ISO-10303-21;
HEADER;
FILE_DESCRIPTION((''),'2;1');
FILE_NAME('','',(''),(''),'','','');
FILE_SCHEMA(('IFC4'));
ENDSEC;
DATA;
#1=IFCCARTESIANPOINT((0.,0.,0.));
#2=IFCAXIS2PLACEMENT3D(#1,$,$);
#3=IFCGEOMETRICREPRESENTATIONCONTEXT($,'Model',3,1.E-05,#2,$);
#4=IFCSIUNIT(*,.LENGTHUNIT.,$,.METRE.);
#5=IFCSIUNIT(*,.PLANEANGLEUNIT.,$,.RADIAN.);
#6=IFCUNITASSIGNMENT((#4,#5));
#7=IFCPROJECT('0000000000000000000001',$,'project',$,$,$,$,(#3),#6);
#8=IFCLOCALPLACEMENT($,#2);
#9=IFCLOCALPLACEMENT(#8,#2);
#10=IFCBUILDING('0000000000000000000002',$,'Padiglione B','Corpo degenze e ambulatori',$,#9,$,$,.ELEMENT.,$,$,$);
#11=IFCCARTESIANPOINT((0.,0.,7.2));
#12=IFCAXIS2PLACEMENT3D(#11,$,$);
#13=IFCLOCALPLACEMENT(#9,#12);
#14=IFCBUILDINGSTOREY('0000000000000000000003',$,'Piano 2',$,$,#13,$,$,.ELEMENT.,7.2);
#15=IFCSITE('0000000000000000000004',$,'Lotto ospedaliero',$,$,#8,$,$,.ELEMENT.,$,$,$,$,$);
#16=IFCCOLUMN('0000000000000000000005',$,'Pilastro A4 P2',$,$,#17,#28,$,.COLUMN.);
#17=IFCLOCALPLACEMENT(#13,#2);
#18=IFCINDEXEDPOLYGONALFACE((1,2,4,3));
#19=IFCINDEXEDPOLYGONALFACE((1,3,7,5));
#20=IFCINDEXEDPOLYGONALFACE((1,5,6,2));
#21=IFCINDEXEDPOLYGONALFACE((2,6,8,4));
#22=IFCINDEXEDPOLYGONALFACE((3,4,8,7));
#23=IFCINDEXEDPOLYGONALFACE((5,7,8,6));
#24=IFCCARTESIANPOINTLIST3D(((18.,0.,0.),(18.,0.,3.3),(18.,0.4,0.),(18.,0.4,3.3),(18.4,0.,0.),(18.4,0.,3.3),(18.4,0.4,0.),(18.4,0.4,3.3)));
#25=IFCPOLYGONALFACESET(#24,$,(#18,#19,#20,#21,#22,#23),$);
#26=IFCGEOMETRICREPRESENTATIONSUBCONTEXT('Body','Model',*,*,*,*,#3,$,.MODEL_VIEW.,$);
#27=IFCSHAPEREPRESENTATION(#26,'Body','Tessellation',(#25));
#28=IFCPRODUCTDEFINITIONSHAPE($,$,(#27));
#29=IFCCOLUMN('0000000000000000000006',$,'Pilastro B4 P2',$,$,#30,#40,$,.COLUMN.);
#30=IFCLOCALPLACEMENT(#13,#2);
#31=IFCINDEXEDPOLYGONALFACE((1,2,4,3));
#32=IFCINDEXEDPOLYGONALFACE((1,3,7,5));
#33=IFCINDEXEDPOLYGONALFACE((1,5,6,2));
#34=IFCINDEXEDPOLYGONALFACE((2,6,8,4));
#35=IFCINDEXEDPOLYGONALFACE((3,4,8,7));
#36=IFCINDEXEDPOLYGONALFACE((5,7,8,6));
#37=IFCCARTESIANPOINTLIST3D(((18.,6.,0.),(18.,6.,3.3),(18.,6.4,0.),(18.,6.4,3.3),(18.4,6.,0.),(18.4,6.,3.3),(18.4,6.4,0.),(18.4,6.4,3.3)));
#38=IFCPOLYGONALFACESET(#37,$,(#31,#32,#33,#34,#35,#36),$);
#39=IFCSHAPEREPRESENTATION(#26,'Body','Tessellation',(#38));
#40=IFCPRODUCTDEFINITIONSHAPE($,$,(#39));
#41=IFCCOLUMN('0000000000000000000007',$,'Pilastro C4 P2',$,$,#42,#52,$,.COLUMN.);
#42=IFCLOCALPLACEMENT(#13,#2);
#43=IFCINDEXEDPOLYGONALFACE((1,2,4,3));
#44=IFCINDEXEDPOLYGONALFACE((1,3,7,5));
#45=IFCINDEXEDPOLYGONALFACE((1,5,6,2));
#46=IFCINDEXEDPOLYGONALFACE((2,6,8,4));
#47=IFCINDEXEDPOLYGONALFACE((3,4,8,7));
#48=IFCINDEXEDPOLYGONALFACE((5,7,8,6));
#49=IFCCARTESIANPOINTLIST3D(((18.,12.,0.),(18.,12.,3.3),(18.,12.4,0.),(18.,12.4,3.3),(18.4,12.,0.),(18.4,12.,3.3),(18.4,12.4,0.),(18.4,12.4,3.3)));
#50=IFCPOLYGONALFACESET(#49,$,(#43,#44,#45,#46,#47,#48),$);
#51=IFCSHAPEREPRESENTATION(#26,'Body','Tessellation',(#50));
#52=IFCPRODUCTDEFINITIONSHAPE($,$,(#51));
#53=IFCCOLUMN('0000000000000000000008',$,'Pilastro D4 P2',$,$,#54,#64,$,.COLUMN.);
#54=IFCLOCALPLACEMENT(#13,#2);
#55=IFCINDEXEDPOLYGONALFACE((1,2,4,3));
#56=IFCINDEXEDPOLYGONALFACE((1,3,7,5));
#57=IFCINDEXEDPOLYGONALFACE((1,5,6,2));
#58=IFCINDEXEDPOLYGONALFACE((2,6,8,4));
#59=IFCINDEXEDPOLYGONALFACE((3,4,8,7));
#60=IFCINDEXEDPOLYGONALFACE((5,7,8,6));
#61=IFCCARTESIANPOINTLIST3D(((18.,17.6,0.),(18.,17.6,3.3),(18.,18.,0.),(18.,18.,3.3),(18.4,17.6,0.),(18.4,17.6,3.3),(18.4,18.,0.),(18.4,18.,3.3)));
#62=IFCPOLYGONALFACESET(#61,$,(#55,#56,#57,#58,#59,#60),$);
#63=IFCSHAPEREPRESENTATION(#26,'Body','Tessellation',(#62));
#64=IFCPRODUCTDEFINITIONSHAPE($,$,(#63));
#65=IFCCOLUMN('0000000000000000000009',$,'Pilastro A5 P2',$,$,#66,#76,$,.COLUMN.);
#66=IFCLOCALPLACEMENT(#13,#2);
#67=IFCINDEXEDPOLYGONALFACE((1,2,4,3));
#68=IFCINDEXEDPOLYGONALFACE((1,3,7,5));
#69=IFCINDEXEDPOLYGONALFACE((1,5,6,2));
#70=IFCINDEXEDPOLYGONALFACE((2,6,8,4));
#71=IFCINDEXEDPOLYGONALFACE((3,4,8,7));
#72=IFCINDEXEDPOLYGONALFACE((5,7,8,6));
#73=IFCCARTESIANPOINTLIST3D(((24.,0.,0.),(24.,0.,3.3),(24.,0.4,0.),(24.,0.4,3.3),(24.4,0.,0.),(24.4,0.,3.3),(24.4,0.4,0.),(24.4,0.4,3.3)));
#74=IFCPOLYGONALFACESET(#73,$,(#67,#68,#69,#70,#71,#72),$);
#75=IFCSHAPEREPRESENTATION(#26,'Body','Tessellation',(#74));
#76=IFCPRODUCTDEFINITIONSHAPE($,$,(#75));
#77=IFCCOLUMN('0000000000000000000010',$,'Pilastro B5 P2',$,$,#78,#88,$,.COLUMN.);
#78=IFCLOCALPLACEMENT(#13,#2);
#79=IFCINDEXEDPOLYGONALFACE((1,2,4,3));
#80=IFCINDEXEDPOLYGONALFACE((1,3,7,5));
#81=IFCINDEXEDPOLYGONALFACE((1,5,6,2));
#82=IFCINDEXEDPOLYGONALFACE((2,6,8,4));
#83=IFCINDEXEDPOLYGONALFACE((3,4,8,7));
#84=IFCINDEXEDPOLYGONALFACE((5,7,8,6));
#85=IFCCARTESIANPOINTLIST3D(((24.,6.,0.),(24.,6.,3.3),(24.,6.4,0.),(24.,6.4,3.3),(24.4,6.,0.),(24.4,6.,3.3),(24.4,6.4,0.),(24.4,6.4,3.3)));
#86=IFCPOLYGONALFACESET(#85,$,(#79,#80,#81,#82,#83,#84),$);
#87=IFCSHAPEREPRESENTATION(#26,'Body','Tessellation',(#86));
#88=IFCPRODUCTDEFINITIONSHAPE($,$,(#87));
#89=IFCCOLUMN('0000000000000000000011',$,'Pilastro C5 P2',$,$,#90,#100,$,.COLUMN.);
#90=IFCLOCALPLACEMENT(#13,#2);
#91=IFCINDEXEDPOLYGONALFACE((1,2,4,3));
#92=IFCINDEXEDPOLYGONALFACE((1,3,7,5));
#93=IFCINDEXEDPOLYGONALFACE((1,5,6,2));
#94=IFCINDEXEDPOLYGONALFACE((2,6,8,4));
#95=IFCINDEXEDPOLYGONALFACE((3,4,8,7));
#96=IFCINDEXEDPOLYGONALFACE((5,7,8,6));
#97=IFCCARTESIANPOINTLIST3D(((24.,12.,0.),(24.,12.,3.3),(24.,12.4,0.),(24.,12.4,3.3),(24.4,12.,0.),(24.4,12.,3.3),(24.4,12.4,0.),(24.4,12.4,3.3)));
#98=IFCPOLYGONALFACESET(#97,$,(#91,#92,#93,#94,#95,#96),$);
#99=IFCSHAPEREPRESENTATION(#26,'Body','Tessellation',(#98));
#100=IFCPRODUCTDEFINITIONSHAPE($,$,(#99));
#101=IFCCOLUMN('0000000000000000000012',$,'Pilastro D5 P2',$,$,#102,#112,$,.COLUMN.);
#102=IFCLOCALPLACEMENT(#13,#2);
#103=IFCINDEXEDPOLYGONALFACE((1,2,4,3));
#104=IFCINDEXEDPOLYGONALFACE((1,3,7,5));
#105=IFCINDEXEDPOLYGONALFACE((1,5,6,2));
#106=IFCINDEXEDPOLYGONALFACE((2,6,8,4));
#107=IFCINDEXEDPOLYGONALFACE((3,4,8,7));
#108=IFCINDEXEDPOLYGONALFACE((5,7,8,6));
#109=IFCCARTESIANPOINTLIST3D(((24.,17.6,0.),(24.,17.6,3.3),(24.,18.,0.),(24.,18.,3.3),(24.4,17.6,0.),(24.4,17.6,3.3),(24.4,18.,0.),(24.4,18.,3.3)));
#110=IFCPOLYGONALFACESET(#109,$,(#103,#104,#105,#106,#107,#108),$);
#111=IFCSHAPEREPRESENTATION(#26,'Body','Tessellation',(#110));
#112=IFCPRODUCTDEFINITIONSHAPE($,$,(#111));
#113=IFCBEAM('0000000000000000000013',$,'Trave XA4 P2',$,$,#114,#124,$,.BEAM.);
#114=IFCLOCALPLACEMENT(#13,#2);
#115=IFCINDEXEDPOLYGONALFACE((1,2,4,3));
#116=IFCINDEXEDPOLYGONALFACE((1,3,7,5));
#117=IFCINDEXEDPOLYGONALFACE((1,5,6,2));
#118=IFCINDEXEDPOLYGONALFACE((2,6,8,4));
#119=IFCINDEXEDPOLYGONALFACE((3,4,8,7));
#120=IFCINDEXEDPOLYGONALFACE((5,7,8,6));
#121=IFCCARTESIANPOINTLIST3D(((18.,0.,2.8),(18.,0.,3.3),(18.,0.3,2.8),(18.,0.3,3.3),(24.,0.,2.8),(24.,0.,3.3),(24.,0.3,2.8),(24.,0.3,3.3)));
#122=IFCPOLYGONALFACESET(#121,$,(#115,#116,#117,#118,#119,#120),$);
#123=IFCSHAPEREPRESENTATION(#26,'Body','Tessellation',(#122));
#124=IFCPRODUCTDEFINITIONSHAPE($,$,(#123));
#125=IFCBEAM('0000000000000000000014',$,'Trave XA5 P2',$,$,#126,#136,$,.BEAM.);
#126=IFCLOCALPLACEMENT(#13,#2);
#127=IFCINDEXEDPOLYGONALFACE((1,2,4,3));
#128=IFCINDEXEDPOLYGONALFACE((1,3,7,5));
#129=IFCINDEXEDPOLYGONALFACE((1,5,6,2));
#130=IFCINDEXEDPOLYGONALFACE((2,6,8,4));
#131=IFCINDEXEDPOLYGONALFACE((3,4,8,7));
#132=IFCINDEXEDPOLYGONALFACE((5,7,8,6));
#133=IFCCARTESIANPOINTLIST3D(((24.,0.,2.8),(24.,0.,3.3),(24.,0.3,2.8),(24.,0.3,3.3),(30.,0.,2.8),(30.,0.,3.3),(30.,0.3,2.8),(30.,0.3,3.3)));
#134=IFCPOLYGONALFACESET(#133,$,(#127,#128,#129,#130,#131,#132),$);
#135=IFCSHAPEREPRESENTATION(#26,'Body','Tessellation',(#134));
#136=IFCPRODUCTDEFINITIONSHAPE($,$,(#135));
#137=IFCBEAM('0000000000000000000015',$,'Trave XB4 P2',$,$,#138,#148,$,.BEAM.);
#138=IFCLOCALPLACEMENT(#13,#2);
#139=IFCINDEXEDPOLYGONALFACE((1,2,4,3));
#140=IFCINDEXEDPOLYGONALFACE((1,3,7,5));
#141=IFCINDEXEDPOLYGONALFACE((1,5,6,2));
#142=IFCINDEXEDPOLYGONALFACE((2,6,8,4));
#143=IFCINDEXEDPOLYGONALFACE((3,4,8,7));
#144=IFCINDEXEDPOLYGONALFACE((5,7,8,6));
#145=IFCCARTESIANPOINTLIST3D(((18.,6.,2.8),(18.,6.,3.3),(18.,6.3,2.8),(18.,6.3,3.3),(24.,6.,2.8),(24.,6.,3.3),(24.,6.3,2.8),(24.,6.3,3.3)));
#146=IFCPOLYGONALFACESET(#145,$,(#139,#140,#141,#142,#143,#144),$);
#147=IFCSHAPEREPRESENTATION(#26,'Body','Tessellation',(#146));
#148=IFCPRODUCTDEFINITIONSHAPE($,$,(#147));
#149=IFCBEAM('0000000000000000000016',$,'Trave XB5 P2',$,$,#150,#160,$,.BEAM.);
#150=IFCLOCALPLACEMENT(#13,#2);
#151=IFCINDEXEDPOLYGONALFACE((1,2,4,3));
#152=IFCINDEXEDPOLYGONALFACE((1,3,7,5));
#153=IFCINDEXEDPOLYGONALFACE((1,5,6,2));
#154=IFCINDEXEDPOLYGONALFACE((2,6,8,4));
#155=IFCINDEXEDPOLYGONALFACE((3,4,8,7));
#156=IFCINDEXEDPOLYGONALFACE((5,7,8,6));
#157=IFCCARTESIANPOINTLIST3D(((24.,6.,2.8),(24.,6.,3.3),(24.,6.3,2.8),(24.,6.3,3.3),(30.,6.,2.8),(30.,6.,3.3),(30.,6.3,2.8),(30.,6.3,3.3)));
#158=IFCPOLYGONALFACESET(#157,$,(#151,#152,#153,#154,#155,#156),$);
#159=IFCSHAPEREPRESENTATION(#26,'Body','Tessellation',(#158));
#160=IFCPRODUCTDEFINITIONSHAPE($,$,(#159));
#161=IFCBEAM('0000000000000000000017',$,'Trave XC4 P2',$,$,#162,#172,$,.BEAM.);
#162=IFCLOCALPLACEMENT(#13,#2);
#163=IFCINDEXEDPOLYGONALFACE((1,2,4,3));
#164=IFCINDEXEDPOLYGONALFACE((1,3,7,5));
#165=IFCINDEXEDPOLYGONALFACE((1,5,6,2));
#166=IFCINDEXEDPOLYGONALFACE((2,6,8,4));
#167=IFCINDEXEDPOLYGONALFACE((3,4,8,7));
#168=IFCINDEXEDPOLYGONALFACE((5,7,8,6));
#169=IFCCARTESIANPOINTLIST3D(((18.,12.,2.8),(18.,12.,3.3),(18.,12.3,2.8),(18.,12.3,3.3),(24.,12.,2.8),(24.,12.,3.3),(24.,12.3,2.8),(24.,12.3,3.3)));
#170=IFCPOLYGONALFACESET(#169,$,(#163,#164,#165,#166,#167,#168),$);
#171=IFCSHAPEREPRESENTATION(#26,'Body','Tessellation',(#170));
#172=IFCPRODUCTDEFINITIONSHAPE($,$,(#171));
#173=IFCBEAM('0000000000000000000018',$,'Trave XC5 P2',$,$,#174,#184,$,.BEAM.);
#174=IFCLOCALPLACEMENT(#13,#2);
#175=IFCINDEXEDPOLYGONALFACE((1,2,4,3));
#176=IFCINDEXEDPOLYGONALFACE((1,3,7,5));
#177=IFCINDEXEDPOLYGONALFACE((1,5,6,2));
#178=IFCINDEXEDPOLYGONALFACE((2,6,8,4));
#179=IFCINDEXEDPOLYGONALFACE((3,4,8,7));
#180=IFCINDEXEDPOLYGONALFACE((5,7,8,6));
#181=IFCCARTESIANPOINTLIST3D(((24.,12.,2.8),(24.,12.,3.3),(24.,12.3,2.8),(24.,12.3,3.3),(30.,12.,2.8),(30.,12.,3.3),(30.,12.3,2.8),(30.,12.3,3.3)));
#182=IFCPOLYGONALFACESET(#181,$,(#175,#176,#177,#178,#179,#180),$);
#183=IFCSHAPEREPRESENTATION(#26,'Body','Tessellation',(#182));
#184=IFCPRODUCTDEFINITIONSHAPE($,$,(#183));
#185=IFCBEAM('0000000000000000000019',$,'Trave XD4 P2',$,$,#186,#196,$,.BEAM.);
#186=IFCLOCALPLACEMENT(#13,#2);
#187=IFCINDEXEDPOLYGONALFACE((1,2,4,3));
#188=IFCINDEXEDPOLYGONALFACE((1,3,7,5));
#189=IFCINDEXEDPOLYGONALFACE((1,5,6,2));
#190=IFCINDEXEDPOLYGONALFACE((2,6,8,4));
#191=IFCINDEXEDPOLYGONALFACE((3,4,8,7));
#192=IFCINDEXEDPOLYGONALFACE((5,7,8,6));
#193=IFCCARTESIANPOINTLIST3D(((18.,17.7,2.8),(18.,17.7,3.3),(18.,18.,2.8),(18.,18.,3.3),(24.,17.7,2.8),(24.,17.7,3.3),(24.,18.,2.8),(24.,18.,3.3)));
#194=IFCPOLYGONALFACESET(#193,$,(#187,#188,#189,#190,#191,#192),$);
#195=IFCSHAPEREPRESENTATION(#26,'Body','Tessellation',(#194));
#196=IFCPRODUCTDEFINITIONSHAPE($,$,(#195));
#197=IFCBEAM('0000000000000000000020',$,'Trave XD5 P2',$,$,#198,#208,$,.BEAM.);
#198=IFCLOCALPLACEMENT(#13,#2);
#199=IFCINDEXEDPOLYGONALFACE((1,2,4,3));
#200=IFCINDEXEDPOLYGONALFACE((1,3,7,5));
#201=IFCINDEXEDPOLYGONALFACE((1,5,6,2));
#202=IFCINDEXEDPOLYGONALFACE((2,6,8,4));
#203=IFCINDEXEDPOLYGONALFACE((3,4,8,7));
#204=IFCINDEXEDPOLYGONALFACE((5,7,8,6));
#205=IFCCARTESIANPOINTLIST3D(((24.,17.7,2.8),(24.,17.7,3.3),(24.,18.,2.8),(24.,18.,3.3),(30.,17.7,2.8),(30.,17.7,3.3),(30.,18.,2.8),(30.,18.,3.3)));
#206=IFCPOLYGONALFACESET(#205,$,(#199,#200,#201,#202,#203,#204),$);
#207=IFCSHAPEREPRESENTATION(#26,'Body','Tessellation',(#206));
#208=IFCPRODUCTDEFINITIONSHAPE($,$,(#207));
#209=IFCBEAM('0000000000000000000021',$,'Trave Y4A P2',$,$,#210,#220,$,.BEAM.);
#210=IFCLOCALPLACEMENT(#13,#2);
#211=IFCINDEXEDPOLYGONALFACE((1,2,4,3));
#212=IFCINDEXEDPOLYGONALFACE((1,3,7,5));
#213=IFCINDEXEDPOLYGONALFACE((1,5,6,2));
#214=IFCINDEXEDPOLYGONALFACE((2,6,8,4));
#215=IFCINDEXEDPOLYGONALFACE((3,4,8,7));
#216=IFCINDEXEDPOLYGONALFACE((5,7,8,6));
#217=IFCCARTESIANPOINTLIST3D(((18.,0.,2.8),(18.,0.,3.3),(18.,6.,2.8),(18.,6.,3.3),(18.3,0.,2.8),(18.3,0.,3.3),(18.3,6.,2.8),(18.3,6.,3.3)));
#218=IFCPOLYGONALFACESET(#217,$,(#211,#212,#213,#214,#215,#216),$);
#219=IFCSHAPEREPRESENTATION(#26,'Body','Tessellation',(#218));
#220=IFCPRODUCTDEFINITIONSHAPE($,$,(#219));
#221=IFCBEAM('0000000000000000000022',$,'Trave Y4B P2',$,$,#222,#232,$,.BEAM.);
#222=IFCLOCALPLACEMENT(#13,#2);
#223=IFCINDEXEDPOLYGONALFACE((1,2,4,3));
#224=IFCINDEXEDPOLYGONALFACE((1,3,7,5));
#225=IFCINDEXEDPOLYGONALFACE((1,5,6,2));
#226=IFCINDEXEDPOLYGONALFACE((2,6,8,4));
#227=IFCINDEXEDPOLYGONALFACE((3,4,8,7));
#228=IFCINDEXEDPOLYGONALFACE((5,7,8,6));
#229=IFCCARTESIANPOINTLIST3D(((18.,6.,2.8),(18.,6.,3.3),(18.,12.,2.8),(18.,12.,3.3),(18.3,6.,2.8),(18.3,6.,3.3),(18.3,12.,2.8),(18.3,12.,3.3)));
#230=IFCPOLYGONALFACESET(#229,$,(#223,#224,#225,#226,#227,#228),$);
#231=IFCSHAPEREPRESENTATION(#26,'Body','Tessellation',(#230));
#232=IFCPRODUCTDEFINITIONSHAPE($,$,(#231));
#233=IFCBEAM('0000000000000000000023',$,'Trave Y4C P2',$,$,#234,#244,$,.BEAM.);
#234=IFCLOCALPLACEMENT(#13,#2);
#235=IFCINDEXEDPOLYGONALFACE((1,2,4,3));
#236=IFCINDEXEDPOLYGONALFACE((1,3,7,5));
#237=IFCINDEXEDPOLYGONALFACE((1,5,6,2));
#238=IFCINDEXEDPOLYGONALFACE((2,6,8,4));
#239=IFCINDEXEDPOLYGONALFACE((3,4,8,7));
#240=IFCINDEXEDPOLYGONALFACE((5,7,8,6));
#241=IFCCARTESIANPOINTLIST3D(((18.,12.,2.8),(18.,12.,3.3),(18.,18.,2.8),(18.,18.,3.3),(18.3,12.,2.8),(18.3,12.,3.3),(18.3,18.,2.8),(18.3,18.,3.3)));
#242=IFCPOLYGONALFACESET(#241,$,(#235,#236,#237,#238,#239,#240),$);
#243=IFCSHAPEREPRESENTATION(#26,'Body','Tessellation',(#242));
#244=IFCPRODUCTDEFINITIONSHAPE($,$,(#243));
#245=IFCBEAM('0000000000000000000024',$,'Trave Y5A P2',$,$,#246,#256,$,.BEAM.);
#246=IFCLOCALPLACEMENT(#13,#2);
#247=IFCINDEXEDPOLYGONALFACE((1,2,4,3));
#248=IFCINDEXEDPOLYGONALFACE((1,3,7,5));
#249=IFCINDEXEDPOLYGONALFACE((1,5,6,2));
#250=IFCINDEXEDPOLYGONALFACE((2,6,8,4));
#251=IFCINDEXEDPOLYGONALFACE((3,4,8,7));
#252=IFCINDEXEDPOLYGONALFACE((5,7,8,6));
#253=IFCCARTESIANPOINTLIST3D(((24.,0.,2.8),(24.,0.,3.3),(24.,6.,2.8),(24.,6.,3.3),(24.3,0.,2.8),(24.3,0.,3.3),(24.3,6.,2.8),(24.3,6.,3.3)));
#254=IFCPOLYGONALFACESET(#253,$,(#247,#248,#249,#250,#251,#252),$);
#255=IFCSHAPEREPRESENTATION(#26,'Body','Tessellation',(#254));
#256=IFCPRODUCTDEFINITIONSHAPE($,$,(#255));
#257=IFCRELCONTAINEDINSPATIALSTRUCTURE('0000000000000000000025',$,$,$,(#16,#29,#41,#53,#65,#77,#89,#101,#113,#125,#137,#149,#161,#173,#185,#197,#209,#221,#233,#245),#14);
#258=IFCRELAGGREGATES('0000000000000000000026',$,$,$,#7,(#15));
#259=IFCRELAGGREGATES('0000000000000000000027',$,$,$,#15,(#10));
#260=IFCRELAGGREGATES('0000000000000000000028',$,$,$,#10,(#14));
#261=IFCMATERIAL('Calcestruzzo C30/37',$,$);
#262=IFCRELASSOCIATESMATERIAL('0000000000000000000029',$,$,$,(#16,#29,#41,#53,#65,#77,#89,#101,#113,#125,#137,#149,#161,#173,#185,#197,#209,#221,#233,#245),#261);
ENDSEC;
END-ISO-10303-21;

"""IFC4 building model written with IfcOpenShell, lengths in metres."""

from ifc_helpers import new_model, si_unit, frame, frame_2d, origin, place, context, subcontext, project, spatial, rectangle, extrude, material, element, save


model = new_model("IFC4")

# Units and contexts
model_context = context("Model", 3, precision=1e-05, world=origin())
body_context = subcontext(model_context, "Body", "Model", "MODEL_VIEW")
ifc_project = project(units=[si_unit("LENGTHUNIT", "METRE"), si_unit("PLANEANGLEUNIT", "RADIAN")], contexts=[model_context])

# Site, building, storey
site_placement = place(None, origin())
site = spatial("IfcSite", under=ifc_project, at=site_placement, Name="Lotto ospedaliero", CompositionType="ELEMENT")
building_placement = place(site_placement, origin())
building = spatial("IfcBuilding", under=site, at=building_placement, Name="Padiglione B", Description="Corpo degenze e ambulatori", CompositionType="ELEMENT")
storey_placement = place(building_placement, frame((0.0, 0.0, 7.2)))
storey = spatial("IfcBuildingStorey", under=building, at=storey_placement, Name="Piano 2", CompositionType="ELEMENT", Elevation=7.2)

# Columns
ifc_material_1 = material(Name="Calcestruzzo C30/37")
for number, where, name in (
    (1, (18.0, 0.0, 0.0), "Pilastro A4 P2"),
    (2, (18.0, 6.0, 0.0), "Pilastro B4 P2"),
    (3, (18.0, 12.0, 0.0), "Pilastro C4 P2"),
    (4, (18.0, 17.6, 0.0), "Pilastro D4 P2"),
    (5, (24.0, 0.0, 0.0), "Pilastro A5 P2"),
    (6, (24.0, 6.0, 0.0), "Pilastro B5 P2"),
    (7, (24.0, 12.0, 0.0), "Pilastro C5 P2"),
    (8, (24.0, 17.6, 0.0), "Pilastro D5 P2"),
):
    element("IfcColumn", number, at=place(storey_placement, frame(where)), inside=storey, material=ifc_material_1, Name=name, PredefinedType="COLUMN", context=body_context, shape_type="SweptSolid", body=[
        extrude(rectangle(XDim=0.4, YDim=0.4, at=frame_2d((0.2, 0.2))), origin(), (0.0, 0.0, 1.0), 3.3),
    ])

# Beams
for number, where, name in (
    (9, (18.0, 0.0, 2.8), "Trave XA4 P2"),
    (10, (24.0, 0.0, 2.8), "Trave XA5 P2"),
    (11, (18.0, 6.0, 2.8), "Trave XB4 P2"),
    (12, (24.0, 6.0, 2.8), "Trave XB5 P2"),
    (13, (18.0, 12.0, 2.8), "Trave XC4 P2"),
    (14, (24.0, 12.0, 2.8), "Trave XC5 P2"),
    (15, (18.0, 17.7, 2.8), "Trave XD4 P2"),
    (16, (24.0, 17.7, 2.8), "Trave XD5 P2"),
):
    element("IfcBeam", number, at=place(storey_placement, frame(where)), inside=storey, material=ifc_material_1, Name=name, PredefinedType="BEAM", context=body_context, shape_type="SweptSolid", body=[
        extrude(rectangle(XDim=6.0, YDim=0.3, at=frame_2d((3.0, 0.15))), origin(), (0.0, 0.0, 1.0), 0.5),
    ])
for number, where, name in (
    (17, (18.0, 0.0, 2.8), "Trave Y4A P2"),
    (18, (18.0, 6.0, 2.8), "Trave Y4B P2"),
    (19, (18.0, 12.0, 2.8), "Trave Y4C P2"),
    (20, (24.0, 0.0, 2.8), "Trave Y5A P2"),
):
    element("IfcBeam", number, at=place(storey_placement, frame(where)), inside=storey, material=ifc_material_1, Name=name, PredefinedType="BEAM", context=body_context, shape_type="SweptSolid", body=[
        extrude(rectangle(XDim=0.3, YDim=6.0, at=frame_2d((0.15, 3.0))), origin(), (0.0, 0.0, 1.0), 0.5),
    ])

save(model, "model.ifc")
